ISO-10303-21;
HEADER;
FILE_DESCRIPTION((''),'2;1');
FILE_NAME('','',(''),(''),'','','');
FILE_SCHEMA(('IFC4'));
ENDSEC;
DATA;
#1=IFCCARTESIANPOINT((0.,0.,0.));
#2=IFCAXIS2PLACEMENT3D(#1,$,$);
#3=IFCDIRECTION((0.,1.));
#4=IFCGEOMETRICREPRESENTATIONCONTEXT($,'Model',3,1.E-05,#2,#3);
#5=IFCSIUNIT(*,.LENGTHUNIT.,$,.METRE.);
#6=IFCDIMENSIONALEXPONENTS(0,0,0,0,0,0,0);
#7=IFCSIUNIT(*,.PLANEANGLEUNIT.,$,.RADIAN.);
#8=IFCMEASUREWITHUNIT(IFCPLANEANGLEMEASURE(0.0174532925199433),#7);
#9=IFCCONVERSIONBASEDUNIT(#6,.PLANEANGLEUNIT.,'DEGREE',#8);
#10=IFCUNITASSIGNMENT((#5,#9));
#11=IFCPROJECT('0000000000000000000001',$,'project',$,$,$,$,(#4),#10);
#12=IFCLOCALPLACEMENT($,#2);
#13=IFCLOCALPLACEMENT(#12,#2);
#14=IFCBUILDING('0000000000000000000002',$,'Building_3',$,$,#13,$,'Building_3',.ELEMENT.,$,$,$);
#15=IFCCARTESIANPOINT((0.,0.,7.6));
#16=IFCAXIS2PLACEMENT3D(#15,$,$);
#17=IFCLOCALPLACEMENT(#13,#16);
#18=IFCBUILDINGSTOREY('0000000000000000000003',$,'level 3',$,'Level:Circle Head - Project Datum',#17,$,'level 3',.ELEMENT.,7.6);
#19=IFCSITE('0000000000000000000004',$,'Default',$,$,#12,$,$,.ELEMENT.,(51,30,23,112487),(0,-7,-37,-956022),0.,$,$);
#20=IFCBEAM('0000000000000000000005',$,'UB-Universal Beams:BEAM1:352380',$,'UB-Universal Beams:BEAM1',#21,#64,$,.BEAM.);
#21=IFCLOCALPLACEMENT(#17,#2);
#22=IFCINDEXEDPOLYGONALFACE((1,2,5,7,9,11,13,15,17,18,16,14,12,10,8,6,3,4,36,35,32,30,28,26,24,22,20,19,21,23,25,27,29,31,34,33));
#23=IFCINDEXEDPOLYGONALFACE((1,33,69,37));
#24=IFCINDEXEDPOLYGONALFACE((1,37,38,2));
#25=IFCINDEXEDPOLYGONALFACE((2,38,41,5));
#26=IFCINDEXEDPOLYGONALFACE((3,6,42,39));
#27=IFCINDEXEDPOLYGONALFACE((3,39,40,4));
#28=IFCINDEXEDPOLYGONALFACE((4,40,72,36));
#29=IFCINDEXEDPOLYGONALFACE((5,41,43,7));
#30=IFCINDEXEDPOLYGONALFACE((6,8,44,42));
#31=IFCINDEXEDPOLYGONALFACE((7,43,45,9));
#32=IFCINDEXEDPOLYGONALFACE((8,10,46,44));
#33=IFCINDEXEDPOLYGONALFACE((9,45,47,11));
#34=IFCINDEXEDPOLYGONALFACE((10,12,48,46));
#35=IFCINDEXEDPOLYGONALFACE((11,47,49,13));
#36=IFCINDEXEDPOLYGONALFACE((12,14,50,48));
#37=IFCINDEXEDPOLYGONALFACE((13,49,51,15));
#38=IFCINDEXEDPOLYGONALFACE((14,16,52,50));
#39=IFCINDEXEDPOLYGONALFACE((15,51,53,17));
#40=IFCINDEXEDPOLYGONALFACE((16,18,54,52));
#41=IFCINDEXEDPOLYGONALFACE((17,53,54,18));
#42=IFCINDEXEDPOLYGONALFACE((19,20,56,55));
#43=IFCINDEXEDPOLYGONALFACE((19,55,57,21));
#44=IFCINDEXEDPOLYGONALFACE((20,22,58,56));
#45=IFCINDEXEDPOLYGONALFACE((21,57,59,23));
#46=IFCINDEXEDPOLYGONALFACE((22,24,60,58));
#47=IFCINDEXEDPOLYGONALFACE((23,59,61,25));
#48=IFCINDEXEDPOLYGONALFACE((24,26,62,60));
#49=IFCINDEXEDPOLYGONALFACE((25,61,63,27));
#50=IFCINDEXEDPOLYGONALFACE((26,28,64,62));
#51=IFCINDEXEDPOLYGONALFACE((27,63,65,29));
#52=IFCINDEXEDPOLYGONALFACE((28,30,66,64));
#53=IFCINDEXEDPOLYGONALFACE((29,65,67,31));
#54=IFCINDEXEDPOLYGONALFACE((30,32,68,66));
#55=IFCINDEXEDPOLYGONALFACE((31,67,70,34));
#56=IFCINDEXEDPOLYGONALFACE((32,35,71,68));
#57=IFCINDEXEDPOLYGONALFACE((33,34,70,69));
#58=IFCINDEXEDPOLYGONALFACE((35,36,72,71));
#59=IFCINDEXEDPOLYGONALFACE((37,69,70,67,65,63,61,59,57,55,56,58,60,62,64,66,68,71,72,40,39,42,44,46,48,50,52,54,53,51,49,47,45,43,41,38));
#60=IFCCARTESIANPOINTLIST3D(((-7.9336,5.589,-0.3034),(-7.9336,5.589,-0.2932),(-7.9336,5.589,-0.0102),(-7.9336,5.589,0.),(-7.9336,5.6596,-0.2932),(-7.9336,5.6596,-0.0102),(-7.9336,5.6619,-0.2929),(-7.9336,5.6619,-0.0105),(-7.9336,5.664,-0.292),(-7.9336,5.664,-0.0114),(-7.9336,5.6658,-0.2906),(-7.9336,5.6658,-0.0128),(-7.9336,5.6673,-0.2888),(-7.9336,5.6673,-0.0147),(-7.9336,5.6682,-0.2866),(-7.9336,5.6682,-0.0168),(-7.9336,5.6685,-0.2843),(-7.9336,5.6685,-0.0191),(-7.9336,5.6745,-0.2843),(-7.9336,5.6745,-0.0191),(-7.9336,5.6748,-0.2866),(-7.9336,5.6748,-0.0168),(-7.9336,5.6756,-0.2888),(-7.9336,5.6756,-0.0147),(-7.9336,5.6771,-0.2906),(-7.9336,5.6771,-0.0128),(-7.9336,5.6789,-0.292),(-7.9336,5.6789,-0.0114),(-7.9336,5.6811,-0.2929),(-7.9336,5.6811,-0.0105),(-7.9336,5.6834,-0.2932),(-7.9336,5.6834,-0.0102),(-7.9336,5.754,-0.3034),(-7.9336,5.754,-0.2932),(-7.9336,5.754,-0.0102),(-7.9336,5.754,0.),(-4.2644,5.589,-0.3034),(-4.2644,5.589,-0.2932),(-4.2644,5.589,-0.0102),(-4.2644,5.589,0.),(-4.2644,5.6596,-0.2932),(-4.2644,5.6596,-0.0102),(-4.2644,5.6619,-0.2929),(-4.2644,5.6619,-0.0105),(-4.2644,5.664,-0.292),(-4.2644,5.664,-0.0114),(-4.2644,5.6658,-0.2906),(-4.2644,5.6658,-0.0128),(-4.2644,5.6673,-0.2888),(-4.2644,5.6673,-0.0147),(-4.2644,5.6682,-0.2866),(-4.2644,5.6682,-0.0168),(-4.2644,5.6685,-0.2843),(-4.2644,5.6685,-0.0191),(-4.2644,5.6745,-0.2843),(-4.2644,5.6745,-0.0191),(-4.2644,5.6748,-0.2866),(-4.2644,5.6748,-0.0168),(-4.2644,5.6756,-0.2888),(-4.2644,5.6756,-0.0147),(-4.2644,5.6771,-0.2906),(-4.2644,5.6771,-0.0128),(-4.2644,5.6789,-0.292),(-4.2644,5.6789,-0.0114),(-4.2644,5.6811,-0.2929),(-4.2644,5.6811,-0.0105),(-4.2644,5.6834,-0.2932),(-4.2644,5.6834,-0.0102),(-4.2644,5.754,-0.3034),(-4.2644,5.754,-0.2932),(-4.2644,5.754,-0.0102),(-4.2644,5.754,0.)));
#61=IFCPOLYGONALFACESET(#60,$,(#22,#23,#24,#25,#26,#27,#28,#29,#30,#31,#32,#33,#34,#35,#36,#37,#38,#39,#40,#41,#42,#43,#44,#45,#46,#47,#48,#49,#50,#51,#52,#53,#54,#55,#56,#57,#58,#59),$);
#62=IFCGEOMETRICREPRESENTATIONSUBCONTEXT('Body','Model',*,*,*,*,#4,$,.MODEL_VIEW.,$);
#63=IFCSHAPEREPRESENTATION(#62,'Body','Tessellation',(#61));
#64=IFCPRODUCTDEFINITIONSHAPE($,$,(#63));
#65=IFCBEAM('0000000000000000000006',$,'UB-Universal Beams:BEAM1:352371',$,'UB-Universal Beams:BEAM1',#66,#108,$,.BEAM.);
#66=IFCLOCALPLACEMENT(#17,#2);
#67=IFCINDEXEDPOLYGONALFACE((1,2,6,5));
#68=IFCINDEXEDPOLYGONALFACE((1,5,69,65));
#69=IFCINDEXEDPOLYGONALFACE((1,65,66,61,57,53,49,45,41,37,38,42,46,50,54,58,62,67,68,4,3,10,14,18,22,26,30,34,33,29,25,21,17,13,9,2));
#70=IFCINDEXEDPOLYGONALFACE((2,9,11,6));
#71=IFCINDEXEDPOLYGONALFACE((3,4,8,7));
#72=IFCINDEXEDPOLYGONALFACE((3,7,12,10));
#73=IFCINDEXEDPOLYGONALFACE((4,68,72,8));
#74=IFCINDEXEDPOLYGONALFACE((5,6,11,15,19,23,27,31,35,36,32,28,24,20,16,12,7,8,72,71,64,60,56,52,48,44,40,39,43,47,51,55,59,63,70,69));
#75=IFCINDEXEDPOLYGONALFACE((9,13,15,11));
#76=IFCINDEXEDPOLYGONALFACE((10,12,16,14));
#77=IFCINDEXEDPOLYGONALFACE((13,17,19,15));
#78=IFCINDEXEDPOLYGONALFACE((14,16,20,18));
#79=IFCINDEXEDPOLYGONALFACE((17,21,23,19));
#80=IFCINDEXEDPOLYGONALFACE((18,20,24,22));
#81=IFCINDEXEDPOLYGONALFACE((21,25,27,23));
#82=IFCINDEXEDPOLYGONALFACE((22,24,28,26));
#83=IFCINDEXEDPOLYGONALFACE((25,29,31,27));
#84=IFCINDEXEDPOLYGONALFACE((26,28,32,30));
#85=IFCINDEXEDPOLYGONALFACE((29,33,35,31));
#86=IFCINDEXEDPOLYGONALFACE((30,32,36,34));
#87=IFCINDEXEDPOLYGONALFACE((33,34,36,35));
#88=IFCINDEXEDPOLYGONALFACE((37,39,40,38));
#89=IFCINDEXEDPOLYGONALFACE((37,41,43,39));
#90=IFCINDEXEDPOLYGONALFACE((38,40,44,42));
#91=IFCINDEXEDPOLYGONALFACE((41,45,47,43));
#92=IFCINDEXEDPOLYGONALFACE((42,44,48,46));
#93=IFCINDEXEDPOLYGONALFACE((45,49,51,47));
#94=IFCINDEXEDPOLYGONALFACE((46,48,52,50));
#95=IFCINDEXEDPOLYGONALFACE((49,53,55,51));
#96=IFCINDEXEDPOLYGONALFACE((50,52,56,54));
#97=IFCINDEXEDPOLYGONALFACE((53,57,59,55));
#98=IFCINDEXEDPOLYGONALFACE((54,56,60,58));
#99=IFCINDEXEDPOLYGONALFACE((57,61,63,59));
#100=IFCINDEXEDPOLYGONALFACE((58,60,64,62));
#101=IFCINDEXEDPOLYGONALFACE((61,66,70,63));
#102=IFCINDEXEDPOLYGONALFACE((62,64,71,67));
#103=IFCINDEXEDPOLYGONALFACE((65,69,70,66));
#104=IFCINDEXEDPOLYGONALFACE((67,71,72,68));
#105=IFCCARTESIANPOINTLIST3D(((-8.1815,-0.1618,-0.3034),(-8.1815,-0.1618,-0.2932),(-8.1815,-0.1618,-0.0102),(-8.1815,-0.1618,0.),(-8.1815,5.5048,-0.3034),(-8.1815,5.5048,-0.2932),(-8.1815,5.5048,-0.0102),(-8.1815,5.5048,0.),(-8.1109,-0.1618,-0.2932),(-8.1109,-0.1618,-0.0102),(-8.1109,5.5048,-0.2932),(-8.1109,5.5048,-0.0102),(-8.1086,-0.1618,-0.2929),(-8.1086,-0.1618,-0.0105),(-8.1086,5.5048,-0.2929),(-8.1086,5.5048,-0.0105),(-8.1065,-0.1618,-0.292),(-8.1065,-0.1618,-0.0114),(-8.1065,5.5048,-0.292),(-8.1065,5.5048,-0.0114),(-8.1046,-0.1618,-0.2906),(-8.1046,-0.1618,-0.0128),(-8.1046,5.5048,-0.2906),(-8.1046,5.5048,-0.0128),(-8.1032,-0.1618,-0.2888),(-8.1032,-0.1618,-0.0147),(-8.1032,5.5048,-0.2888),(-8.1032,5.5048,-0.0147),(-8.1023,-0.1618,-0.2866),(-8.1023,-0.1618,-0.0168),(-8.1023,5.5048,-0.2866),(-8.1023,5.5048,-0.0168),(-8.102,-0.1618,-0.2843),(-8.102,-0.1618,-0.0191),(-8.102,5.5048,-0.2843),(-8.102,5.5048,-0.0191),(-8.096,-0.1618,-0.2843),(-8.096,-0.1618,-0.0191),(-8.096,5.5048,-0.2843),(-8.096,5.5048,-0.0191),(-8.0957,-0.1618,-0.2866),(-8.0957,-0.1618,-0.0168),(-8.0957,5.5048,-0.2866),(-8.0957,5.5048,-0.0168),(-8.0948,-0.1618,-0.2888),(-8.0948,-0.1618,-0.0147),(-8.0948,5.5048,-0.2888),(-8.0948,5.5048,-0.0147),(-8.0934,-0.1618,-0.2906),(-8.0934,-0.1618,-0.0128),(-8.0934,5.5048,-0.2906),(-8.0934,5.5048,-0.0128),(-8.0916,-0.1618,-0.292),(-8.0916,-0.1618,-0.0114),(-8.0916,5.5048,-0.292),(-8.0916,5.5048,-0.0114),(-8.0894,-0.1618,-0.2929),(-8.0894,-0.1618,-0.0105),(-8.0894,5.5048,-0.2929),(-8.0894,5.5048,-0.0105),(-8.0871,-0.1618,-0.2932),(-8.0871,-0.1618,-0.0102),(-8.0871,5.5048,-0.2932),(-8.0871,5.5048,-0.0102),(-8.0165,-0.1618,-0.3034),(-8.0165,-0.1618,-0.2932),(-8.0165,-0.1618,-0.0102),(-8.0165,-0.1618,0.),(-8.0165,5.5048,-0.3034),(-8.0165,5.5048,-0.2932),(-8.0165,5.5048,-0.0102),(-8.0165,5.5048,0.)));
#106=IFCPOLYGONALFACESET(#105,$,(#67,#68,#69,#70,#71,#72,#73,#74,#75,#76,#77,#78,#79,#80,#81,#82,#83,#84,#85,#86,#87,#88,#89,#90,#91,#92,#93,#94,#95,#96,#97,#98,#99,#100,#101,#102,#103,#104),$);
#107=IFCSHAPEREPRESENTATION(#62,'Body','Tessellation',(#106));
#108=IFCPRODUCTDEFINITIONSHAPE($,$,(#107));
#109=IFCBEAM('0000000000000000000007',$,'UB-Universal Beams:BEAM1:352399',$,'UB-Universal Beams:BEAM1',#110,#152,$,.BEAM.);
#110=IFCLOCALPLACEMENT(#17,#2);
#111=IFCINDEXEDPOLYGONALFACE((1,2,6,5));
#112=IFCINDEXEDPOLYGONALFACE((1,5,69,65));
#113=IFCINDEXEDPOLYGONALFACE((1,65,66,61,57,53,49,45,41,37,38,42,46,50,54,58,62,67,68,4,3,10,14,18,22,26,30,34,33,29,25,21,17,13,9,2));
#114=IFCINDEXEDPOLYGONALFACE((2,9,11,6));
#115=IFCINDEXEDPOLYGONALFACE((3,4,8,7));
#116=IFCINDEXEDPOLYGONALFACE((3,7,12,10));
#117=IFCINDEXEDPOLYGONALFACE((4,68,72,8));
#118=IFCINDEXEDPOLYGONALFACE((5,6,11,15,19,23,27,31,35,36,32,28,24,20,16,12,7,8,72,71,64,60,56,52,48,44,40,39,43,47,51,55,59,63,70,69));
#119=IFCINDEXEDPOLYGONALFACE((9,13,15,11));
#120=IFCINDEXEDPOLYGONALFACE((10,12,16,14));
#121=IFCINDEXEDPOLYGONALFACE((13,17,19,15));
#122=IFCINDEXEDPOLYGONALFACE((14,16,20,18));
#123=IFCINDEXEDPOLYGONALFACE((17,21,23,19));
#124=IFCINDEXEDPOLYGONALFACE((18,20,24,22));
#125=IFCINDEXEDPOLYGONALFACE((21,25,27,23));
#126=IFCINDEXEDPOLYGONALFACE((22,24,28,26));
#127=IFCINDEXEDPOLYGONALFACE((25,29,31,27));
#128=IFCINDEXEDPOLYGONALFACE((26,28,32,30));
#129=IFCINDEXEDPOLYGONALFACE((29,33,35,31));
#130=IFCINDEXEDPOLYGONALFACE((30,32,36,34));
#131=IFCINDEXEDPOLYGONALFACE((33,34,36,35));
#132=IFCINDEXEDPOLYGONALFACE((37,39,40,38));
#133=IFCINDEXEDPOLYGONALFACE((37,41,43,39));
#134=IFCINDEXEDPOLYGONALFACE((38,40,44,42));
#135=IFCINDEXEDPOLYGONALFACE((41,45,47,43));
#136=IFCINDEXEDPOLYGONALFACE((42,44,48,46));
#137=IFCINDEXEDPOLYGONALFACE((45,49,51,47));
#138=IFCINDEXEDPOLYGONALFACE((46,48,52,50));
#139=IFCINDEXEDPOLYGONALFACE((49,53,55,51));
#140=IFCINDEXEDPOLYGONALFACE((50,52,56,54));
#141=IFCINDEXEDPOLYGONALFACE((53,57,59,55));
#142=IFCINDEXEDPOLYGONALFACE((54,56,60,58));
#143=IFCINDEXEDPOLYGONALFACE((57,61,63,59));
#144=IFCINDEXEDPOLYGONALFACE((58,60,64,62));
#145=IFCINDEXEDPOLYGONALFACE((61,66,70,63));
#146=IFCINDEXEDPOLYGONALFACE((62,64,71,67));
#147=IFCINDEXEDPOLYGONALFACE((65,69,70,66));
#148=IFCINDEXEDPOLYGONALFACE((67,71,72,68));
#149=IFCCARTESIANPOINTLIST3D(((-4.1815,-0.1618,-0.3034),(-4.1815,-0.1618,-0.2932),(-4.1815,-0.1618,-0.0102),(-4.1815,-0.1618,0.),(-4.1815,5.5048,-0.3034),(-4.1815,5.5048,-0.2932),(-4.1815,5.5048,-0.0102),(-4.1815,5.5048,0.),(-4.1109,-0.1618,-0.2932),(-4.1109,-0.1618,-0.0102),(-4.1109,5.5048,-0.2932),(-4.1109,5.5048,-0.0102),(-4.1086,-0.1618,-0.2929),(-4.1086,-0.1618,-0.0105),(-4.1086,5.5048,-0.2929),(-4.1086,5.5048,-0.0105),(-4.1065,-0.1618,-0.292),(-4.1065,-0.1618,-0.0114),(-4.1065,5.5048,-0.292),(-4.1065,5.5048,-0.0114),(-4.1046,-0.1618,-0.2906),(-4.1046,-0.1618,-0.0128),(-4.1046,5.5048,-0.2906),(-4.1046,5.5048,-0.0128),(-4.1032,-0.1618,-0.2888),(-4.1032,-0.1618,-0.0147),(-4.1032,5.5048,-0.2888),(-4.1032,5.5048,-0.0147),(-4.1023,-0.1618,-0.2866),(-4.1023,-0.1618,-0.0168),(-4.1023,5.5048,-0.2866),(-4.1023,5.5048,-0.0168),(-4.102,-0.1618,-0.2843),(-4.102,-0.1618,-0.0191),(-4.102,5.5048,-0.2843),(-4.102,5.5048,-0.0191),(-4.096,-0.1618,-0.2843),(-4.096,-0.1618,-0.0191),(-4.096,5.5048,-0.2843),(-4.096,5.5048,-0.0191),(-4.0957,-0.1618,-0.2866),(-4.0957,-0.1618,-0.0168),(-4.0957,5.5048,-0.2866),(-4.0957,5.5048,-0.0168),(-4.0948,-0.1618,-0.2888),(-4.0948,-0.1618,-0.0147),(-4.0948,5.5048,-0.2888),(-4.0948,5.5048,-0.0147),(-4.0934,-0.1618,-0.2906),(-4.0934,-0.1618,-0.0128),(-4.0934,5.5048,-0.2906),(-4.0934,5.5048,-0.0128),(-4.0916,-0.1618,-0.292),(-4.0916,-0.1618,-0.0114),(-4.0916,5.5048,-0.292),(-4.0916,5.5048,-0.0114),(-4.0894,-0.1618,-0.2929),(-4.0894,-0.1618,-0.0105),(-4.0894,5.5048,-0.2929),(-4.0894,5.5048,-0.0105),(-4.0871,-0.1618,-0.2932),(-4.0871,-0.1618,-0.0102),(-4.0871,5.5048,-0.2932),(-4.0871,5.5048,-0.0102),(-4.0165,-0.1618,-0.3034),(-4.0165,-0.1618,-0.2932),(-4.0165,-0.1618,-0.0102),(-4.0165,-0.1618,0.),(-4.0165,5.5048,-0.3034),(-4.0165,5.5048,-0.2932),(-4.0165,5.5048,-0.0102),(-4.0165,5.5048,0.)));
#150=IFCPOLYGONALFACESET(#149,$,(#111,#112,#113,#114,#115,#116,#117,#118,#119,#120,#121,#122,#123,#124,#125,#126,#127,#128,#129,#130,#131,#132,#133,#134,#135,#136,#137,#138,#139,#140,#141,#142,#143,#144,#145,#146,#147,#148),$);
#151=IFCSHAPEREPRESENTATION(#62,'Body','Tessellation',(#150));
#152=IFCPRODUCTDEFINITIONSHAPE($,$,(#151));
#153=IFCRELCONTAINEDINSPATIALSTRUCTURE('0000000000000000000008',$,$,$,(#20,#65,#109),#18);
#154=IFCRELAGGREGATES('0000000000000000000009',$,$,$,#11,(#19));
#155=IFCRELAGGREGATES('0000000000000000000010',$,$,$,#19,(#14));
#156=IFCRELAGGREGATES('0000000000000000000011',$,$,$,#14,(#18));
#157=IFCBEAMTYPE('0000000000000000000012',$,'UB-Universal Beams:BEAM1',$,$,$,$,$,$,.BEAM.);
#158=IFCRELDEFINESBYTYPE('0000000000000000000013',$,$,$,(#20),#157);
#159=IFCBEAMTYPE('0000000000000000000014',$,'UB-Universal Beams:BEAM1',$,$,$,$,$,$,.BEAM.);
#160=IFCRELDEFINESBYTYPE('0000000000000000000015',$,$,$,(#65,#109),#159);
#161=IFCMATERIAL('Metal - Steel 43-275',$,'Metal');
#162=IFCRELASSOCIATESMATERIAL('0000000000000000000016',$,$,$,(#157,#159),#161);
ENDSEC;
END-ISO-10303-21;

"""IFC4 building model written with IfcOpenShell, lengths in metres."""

from ifc_helpers import new_model, entity, si_unit, converted_unit, direction, frame, frame_2d, origin, place, context, subcontext, project, spatial, polyline, circle_curve, parameter, trimmed, segment, composite_curve, outline, extrude, source, transform, mapped, material, material_profile, profile_set, type_object, type_shapes, element, save


model = new_model("IFC4")

# Units and contexts
model_context = context("Model", 3, precision=1e-05, world=origin(), true_north=direction((0.0, 1.0)))
body_context = subcontext(model_context, "Body", "Model", "MODEL_VIEW")
ifc_project = project(units=[si_unit("LENGTHUNIT", "METRE"), converted_unit("PLANEANGLEUNIT", "DEGREE", entity("IfcPlaneAngleMeasure", 0.0174532925199433), si_unit("PLANEANGLEUNIT", "RADIAN"), dimensions=[0, 0, 0, 0, 0, 0, 0])], contexts=[model_context])

# Site, building, storey
site_placement = place(None, origin())
site = spatial("IfcSite", under=ifc_project, at=site_placement, Name="Default", CompositionType="ELEMENT", RefLatitude=(51, 30, 23, 112487), RefLongitude=(0, -7, -37, -956022), RefElevation=0.0)
building_placement = place(site_placement, origin())
building = spatial("IfcBuilding", under=site, at=building_placement, Name="Building_3", LongName="Building_3", CompositionType="ELEMENT")
storey_placement = place(building_placement, frame((0.0, 0.0, 7.6)))
storey = spatial("IfcBuildingStorey", under=building, at=storey_placement, Name="level 3", ObjectType="Level:Circle Head - Project Datum", LongName="level 3", CompositionType="ELEMENT", Elevation=7.6)

# Shared definitions
ifc_material_1 = material(Name="Metal - Steel 43-275", Category="Metal")

# Beams
ifc_material_profile_1 = material_profile(ifc_material_1, outline(composite_curve([segment(polyline([(-0.0825, -0.1415), (-0.0825, -0.1517)]), True, "CONTINUOUS"), segment(polyline([(-0.0825, -0.1517), (0.0825, -0.1517)]), True, "CONTINUOUS"), segment(polyline([(0.0825, -0.1517), (0.0825, -0.1415)]), True, "CONTINUOUS"), segment(polyline([(0.0825, -0.1415), (0.0119, -0.1415)]), True, "CONTINUOUS"), segment(trimmed(circle_curve(frame_2d((0.0119, -0.1326), x_axis=(1.0, 0.0)), 0.0089), [parameter(180.0)], [parameter(270.0)], True, "PARAMETER"), False, "CONTINUOUS"), segment(polyline([(0.003, -0.1326), (0.003, 0.1326)]), True, "CONTINUOUS"), segment(trimmed(circle_curve(frame_2d((0.0119, 0.1326), x_axis=(1.0, 0.0)), 0.0089), [parameter(90.0)], [parameter(180.0)], True, "PARAMETER"), False, "CONTINUOUS"), segment(polyline([(0.0119, 0.1415), (0.0825, 0.1415)]), True, "CONTINUOUS"), segment(polyline([(0.0825, 0.1415), (0.0825, 0.1517)]), True, "CONTINUOUS"), segment(polyline([(0.0825, 0.1517), (-0.0825, 0.1517)]), True, "CONTINUOUS"), segment(polyline([(-0.0825, 0.1517), (-0.0825, 0.1415)]), True, "CONTINUOUS"), segment(polyline([(-0.0825, 0.1415), (-0.0119, 0.1415)]), True, "CONTINUOUS"), segment(trimmed(circle_curve(frame_2d((-0.0119, 0.1326), x_axis=(1.0, 0.0)), 0.0089), [parameter(360.0)], [parameter(90.0)], True, "PARAMETER"), False, "CONTINUOUS"), segment(polyline([(-0.003, 0.1326), (-0.003, -0.1326)]), True, "CONTINUOUS"), segment(trimmed(circle_curve(frame_2d((-0.0119, -0.1326), x_axis=(1.0, 0.0)), 0.0089), [parameter(270.0)], [parameter(360.0)], True, "PARAMETER"), False, "CONTINUOUS"), segment(polyline([(-0.0119, -0.1415), (-0.0825, -0.1415)]), True, "CONTINUOUS")], self_intersect=False)), Name="BEAM1")
ifc_profile_set_1 = profile_set([ifc_material_profile_1], Name="BEAM1")
beam_type_1 = type_object("IfcBeamType", Name="UB-Universal Beams:BEAM1", PredefinedType="BEAM", material=ifc_profile_set_1)
shared_shape_1 = source(origin(), body_context, "Body", "SweptSolid", [
    extrude(outline(composite_curve([segment(polyline([(-0.0825, -0.1415), (-0.0825, -0.1517)]), True, "CONTINUOUS"), segment(polyline([(-0.0825, -0.1517), (0.0825, -0.1517)]), True, "CONTINUOUS"), segment(polyline([(0.0825, -0.1517), (0.0825, -0.1415)]), True, "CONTINUOUS"), segment(polyline([(0.0825, -0.1415), (0.0119, -0.1415)]), True, "CONTINUOUS"), segment(trimmed(circle_curve(frame_2d((0.0119, -0.1326), x_axis=(0.0, -1.0)), 0.0089), [parameter(270.0)], [parameter(360.0)], True, "PARAMETER"), False, "CONTINUOUS"), segment(polyline([(0.003, -0.1326), (0.003, 0.1326)]), True, "CONTINUOUS"), segment(trimmed(circle_curve(frame_2d((0.0119, 0.1326), x_axis=(-1.0, 0.0)), 0.0089), [parameter(270.0)], [parameter(360.0)], True, "PARAMETER"), False, "CONTINUOUS"), segment(polyline([(0.0119, 0.1415), (0.0825, 0.1415)]), True, "CONTINUOUS"), segment(polyline([(0.0825, 0.1415), (0.0825, 0.1517)]), True, "CONTINUOUS"), segment(polyline([(0.0825, 0.1517), (-0.0825, 0.1517)]), True, "CONTINUOUS"), segment(polyline([(-0.0825, 0.1517), (-0.0825, 0.1415)]), True, "CONTINUOUS"), segment(polyline([(-0.0825, 0.1415), (-0.0119, 0.1415)]), True, "CONTINUOUS"), segment(trimmed(circle_curve(frame_2d((-0.0119, 0.1326), x_axis=(0.0, 1.0)), 0.0089), [parameter(270.0)], [parameter(360.0)], True, "PARAMETER"), False, "CONTINUOUS"), segment(polyline([(-0.003, 0.1326), (-0.003, -0.1326)]), True, "CONTINUOUS"), segment(trimmed(circle_curve(frame_2d((-0.0119, -0.1326), x_axis=(1.0, 0.0)), 0.0089), [parameter(270.0)], [parameter(0.0)], True, "PARAMETER"), False, "CONTINUOUS"), segment(polyline([(-0.0119, -0.1415), (-0.0825, -0.1415)]), True, "CONTINUOUS")], self_intersect=False)), frame((-1.8346, 0.0, 0.0), z_axis=(-1.0, 0.0, 0.0), x_axis=(0.0, -1.0, 0.0)), (0.0, 0.0, -1.0), 3.6692),
])
type_shapes(beam_type_1, [shared_shape_1])
beam_1_placement = place(storey_placement, frame((-6.099, 5.6715, -0.1517)))
element("IfcBeam", 1, at=beam_1_placement, inside=storey, type_object=beam_type_1, Name="UB-Universal Beams:BEAM1:352380", ObjectType="UB-Universal Beams:BEAM1", PredefinedType="BEAM", context=body_context, shape_type="MappedRepresentation", body=[
    mapped(shared_shape_1, transform((0.0, 0.0, 0.0), scale=1.0)),
])
beam_type_2 = type_object("IfcBeamType", Name="UB-Universal Beams:BEAM1", PredefinedType="BEAM", material=ifc_profile_set_1)
shared_shape_2 = source(origin(), body_context, "Body", "SweptSolid", [
    extrude(outline(composite_curve([segment(polyline([(-0.0825, -0.1415), (-0.0825, -0.1517)]), True, "CONTINUOUS"), segment(polyline([(-0.0825, -0.1517), (0.0825, -0.1517)]), True, "CONTINUOUS"), segment(polyline([(0.0825, -0.1517), (0.0825, -0.1415)]), True, "CONTINUOUS"), segment(polyline([(0.0825, -0.1415), (0.0119, -0.1415)]), True, "CONTINUOUS"), segment(trimmed(circle_curve(frame_2d((0.0119, -0.1326), x_axis=(1.0, 0.0)), 0.0089), [parameter(180.0)], [parameter(270.0)], True, "PARAMETER"), False, "CONTINUOUS"), segment(polyline([(0.003, -0.1326), (0.003, 0.1326)]), True, "CONTINUOUS"), segment(trimmed(circle_curve(frame_2d((0.0119, 0.1326), x_axis=(1.0, 0.0)), 0.0089), [parameter(90.0)], [parameter(180.0)], True, "PARAMETER"), False, "CONTINUOUS"), segment(polyline([(0.0119, 0.1415), (0.0825, 0.1415)]), True, "CONTINUOUS"), segment(polyline([(0.0825, 0.1415), (0.0825, 0.1517)]), True, "CONTINUOUS"), segment(polyline([(0.0825, 0.1517), (-0.0825, 0.1517)]), True, "CONTINUOUS"), segment(polyline([(-0.0825, 0.1517), (-0.0825, 0.1415)]), True, "CONTINUOUS"), segment(polyline([(-0.0825, 0.1415), (-0.0119, 0.1415)]), True, "CONTINUOUS"), segment(trimmed(circle_curve(frame_2d((-0.0119, 0.1326), x_axis=(1.0, 0.0)), 0.0089), [parameter(360.0)], [parameter(90.0)], True, "PARAMETER"), False, "CONTINUOUS"), segment(polyline([(-0.003, 0.1326), (-0.003, -0.1326)]), True, "CONTINUOUS"), segment(trimmed(circle_curve(frame_2d((-0.0119, -0.1326), x_axis=(1.0, 0.0)), 0.0089), [parameter(270.0)], [parameter(360.0)], True, "PARAMETER"), False, "CONTINUOUS"), segment(polyline([(-0.0119, -0.1415), (-0.0825, -0.1415)]), True, "CONTINUOUS")], self_intersect=False)), frame((-2.8333, 0.0, 0.0), z_axis=(-1.0, 0.0, 0.0), x_axis=(0.0, -1.0, 0.0)), (0.0, 0.0, -1.0), 5.6666),
])
type_shapes(beam_type_2, [shared_shape_2])
for number, where, z_axis, x_axis, name in (
    (2, (-8.099, 2.6715, -0.1517), (0.0, 0.0, 1.0), (0.0, -1.0, 0.0), "UB-Universal Beams:BEAM1:352371"),
    (3, (-4.099, 2.6715, -0.1517), (0.0, 0.0, 1.0), (0.0, -1.0, 0.0), "UB-Universal Beams:BEAM1:352399"),
):
    element("IfcBeam", number, at=place(storey_placement, frame(where, z_axis=z_axis, x_axis=x_axis)), inside=storey, type_object=beam_type_2, Name=name, ObjectType="UB-Universal Beams:BEAM1", PredefinedType="BEAM", context=body_context, shape_type="MappedRepresentation", body=[
        mapped(shared_shape_2, transform((0.0, 0.0, 0.0), scale=1.0)),
    ])

save(model, "model.ifc")
